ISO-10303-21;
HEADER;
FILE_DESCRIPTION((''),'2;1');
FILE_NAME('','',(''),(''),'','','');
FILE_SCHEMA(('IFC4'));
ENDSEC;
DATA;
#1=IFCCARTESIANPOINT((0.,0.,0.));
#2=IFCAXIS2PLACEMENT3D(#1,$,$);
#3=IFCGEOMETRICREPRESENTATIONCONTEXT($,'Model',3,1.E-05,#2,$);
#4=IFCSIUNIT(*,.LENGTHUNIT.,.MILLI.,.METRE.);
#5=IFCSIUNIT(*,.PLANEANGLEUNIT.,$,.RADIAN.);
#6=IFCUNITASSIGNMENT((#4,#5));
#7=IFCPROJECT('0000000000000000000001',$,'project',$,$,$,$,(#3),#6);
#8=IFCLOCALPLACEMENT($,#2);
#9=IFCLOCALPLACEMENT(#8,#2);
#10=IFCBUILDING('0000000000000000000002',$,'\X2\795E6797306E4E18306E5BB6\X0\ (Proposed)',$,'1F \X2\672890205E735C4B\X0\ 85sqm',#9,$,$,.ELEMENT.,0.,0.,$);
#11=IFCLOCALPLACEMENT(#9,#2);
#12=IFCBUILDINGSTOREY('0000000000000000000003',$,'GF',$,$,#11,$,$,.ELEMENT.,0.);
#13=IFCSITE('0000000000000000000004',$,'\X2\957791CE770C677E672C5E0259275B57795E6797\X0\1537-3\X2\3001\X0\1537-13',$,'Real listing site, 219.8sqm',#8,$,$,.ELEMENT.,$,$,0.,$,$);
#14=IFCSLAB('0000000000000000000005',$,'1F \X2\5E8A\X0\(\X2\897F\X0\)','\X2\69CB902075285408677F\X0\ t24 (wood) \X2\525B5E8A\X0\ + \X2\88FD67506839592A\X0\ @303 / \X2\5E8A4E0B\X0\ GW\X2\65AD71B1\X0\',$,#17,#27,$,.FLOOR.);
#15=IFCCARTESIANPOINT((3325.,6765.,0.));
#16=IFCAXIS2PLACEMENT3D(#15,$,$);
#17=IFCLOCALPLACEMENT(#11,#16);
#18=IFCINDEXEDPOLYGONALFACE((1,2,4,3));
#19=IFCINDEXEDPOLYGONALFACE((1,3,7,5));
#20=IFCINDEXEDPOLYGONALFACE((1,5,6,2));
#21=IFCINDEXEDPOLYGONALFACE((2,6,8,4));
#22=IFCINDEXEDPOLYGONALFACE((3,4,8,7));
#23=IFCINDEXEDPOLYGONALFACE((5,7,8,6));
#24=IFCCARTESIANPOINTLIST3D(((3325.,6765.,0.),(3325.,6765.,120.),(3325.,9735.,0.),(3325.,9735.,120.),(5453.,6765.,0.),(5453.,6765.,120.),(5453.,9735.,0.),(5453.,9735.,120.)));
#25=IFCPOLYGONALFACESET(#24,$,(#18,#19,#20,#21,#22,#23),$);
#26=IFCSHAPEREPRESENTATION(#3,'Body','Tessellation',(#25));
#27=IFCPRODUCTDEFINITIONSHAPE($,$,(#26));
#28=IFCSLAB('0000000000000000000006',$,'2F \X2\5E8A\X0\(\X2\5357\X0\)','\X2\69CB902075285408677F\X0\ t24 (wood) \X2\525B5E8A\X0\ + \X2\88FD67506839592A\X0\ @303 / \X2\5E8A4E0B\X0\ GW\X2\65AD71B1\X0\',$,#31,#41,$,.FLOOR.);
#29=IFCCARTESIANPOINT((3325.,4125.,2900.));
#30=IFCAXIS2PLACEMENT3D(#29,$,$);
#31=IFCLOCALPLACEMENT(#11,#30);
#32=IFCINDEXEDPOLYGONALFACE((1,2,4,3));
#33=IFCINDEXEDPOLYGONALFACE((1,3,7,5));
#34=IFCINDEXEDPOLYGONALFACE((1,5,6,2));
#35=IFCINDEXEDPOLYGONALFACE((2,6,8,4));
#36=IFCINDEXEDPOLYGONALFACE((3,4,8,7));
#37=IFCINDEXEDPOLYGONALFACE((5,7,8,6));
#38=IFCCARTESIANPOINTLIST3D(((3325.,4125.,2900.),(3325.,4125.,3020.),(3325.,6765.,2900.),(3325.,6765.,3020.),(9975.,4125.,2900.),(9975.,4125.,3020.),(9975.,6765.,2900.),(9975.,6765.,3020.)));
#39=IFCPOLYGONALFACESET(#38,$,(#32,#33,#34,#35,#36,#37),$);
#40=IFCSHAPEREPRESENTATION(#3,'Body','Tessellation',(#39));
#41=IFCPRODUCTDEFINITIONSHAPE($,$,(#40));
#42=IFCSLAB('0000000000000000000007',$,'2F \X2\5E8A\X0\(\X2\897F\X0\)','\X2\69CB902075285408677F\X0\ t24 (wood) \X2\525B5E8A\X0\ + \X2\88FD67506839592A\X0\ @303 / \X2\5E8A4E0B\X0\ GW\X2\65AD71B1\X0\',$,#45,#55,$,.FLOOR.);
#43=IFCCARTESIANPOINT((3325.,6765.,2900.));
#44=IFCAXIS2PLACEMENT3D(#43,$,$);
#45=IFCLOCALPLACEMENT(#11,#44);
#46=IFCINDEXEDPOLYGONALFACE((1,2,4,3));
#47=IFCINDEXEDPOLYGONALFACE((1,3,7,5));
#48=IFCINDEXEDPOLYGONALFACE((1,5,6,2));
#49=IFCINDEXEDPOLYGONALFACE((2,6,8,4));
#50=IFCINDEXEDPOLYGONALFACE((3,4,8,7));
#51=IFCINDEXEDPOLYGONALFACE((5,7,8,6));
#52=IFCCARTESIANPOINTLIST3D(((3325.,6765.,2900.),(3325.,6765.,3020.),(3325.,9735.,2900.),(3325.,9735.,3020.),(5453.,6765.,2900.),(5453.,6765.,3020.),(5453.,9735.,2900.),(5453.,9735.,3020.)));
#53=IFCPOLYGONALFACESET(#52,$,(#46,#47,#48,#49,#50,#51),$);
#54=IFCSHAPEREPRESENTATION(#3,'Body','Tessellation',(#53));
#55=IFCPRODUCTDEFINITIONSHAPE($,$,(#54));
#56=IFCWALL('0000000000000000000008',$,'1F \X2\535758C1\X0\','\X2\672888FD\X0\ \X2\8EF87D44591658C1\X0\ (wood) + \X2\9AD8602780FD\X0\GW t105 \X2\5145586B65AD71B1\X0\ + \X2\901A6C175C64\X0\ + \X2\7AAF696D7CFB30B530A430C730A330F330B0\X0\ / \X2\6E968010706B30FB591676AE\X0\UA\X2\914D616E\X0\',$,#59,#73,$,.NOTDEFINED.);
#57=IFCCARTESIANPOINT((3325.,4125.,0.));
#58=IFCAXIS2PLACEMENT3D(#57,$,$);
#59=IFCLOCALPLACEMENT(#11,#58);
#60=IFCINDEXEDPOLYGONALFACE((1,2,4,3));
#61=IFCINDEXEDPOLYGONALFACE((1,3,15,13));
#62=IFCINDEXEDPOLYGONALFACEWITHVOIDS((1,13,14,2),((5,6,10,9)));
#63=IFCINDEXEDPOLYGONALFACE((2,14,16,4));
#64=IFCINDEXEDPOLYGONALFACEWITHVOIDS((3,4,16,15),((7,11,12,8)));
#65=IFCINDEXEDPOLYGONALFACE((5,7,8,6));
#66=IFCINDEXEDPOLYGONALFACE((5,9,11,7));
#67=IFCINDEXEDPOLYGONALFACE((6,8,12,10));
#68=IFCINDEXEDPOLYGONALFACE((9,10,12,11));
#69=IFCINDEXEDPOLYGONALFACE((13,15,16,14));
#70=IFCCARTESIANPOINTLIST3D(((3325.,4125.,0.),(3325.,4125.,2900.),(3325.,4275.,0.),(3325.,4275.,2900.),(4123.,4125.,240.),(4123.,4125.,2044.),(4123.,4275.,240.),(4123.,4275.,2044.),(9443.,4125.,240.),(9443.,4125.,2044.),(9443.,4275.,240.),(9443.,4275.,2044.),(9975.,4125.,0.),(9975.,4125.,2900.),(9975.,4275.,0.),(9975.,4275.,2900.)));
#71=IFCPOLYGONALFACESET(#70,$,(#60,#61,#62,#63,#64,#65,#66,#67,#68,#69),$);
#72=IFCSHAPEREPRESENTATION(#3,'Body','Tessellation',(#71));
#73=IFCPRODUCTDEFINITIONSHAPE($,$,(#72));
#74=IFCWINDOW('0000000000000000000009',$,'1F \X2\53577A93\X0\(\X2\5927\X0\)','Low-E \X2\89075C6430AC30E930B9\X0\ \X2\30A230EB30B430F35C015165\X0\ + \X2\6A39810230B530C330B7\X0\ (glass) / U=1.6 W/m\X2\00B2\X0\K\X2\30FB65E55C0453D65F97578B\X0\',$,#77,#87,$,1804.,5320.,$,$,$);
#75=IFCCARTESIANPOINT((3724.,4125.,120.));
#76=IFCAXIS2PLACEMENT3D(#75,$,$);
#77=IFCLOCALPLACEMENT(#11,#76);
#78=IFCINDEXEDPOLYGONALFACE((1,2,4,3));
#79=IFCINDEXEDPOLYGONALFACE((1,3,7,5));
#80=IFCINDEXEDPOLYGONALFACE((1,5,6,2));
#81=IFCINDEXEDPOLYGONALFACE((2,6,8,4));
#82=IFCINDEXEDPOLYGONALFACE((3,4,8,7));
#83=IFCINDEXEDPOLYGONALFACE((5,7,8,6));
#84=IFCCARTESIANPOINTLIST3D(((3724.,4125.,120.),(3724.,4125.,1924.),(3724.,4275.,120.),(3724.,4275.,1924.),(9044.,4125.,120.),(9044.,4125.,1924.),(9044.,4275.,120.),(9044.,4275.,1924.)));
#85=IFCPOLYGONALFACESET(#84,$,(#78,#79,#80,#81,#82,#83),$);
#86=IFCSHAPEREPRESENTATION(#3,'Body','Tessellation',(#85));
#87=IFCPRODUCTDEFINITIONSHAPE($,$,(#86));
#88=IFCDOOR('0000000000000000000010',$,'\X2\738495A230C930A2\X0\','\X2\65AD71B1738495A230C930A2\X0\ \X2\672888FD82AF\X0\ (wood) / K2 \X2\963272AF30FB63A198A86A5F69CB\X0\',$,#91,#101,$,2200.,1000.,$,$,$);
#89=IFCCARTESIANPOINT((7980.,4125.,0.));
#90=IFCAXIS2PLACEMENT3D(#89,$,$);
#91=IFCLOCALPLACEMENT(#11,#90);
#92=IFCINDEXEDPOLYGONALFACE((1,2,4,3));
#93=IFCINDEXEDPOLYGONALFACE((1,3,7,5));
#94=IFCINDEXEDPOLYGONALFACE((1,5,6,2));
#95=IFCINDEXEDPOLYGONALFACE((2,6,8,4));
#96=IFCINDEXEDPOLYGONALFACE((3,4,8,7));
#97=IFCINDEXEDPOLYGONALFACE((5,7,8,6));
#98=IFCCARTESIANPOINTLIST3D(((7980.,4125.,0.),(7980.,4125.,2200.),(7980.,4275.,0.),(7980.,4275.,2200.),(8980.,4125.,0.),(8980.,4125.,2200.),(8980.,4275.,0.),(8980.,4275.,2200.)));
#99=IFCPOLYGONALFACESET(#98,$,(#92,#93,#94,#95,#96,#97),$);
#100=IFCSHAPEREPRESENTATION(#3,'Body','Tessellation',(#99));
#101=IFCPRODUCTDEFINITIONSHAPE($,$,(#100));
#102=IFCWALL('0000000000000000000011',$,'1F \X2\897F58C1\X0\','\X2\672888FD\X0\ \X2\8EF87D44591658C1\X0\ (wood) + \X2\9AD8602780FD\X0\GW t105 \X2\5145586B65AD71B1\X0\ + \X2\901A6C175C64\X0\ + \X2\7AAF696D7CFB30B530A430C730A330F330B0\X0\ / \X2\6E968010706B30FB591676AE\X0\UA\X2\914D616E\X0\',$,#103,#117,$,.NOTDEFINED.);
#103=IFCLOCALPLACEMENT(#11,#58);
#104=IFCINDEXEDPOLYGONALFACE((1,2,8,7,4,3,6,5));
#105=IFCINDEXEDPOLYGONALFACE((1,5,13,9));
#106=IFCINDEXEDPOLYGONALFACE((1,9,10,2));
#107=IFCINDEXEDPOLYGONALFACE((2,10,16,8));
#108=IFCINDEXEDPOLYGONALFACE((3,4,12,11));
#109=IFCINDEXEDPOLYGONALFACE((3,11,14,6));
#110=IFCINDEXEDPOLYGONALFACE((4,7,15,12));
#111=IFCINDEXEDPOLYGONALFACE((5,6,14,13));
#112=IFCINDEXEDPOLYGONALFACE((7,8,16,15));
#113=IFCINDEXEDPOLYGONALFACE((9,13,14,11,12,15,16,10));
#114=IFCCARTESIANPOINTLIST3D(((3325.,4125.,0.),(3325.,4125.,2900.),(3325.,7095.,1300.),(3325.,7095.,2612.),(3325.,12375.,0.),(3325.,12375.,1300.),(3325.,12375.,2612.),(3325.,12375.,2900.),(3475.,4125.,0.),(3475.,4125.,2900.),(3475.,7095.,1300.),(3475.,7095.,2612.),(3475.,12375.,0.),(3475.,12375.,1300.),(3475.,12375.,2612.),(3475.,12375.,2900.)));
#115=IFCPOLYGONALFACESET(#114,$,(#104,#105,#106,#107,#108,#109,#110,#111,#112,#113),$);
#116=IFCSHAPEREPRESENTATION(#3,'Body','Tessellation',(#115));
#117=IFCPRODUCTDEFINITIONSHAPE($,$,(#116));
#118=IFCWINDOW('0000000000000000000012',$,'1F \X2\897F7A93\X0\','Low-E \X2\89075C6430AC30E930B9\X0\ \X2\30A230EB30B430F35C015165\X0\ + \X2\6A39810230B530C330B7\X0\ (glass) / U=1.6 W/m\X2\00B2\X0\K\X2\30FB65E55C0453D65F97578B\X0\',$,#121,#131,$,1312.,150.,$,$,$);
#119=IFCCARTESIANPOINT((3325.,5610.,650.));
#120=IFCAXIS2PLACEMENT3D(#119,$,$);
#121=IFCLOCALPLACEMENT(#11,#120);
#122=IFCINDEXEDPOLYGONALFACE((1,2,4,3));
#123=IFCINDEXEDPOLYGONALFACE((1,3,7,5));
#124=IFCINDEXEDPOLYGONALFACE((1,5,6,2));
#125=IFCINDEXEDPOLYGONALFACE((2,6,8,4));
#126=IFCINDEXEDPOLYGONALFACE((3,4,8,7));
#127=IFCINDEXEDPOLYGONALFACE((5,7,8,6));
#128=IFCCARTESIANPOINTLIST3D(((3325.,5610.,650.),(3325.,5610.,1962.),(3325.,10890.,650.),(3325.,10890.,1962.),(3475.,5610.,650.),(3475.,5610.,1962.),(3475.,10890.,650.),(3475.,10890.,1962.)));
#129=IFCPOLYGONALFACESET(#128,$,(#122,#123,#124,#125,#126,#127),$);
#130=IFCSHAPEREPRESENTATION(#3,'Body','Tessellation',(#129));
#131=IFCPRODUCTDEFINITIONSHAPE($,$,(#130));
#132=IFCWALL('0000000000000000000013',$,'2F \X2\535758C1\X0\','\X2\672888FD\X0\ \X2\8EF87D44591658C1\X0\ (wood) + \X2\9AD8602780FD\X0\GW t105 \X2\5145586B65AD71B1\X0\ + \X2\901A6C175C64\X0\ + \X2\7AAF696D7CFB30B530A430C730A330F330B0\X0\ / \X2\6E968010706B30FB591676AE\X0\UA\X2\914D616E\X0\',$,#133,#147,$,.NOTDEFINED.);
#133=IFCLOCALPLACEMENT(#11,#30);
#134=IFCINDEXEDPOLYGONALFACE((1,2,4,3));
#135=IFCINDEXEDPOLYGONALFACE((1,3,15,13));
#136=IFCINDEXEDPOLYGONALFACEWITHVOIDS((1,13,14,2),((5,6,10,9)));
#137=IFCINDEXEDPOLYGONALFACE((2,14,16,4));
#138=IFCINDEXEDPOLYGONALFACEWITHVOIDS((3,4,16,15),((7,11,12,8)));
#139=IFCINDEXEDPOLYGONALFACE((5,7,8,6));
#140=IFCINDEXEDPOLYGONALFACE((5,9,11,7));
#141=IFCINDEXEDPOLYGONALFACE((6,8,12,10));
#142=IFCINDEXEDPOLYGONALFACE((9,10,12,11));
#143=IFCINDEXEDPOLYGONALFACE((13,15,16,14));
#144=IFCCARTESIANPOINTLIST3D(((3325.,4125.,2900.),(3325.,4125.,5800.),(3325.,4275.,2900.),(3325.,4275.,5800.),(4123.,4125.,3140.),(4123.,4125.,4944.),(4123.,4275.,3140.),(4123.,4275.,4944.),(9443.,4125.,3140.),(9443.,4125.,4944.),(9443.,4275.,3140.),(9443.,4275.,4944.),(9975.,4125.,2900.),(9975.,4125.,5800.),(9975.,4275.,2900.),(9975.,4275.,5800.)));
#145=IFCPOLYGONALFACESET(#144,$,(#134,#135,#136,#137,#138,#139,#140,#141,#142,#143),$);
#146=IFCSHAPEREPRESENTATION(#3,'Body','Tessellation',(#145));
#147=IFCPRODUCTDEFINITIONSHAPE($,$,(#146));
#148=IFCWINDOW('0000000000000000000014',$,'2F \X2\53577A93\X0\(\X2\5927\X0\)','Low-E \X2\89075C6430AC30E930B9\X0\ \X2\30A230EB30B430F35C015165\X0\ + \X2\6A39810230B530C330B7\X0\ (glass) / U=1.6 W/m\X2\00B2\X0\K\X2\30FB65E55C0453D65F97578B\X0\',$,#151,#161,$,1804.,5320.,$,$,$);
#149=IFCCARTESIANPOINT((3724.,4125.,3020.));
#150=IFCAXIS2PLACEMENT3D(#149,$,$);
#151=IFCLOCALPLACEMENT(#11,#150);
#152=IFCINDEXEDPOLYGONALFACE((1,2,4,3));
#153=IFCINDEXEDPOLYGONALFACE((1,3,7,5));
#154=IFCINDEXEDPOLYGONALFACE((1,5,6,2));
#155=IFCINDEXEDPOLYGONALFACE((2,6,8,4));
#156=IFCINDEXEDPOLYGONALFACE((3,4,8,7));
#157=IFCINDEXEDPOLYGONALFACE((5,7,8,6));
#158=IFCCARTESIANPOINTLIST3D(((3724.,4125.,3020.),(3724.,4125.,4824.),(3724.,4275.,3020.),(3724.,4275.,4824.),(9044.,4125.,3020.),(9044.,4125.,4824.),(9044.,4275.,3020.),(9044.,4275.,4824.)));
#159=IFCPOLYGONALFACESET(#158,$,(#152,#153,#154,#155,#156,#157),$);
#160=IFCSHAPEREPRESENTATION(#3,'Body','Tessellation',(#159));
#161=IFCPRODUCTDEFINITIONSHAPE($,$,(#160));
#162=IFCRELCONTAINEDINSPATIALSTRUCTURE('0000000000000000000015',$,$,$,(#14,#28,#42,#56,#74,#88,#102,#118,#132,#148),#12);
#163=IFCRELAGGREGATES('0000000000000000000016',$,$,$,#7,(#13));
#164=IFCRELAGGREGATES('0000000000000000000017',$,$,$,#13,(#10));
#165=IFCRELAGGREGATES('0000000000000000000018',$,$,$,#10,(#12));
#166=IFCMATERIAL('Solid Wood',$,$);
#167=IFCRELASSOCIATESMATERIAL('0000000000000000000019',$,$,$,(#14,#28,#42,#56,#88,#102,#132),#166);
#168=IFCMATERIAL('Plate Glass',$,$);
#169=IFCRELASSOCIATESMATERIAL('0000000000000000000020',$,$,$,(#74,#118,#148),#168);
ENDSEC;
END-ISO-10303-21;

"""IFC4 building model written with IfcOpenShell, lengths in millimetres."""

from ifc_helpers import new_model, si_unit, frame, frame_2d, origin, place, context, project, spatial, rectangle, extrude, material, element, fill, save


model = new_model("IFC4")

# Units and contexts
model_context = context("Model", 3, precision=1e-05, world=origin())
ifc_project = project(units=[si_unit("LENGTHUNIT", "METRE", prefix="MILLI"), si_unit("PLANEANGLEUNIT", "RADIAN")], contexts=[model_context])

# Site, building, storey
site_placement = place(None, origin())
site = spatial("IfcSite", under=ifc_project, at=site_placement, Name="長野県松本市大字神林1537-3、1537-13", ObjectType="Real listing site, 219.8sqm", CompositionType="ELEMENT", RefElevation=0.0)
building_placement = place(site_placement, origin())
building = spatial("IfcBuilding", under=site, at=building_placement, Name="神林の丘の家 (Proposed)", ObjectType="1F 木造平屋 85sqm", CompositionType="ELEMENT", ElevationOfRefHeight=0.0, ElevationOfTerrain=0.0)
storey_placement = place(building_placement, origin())
storey = spatial("IfcBuildingStorey", under=building, at=storey_placement, Name="GF", CompositionType="ELEMENT", Elevation=0.0)

# Slabs
ifc_material_1 = material(Name="Solid Wood")
slab_1_placement = place(storey_placement, frame((3325.0, 6765.0, 0.0)))
element("IfcSlab", 1, at=slab_1_placement, inside=storey, material=ifc_material_1, Name="1F 床(西)", Description="構造用合板 t24 (wood) 剛床 + 製材根太 @303 / 床下 GW断熱", PredefinedType="FLOOR", context=model_context, shape_type="SweptSolid", body=[
    extrude(rectangle(XDim=2128.0, YDim=2970.0, at=frame_2d((1064.0, 1485.0))), frame((3325.0, 6765.0, 0.0)), (0.0, 0.0, 1.0), 120.0),
])
slab_2_placement = place(storey_placement, frame((3325.0, 4125.0, 2900.0)))
element("IfcSlab", 2, at=slab_2_placement, inside=storey, material=ifc_material_1, Name="2F 床(南)", Description="構造用合板 t24 (wood) 剛床 + 製材根太 @303 / 床下 GW断熱", PredefinedType="FLOOR", context=model_context, shape_type="SweptSolid", body=[
    extrude(rectangle(XDim=6650.0, YDim=2640.0, at=frame_2d((3325.0, 1320.0))), frame((3325.0, 4125.0, 2900.0)), (0.0, 0.0, 1.0), 120.0),
])
slab_3_placement = place(storey_placement, frame((3325.0, 6765.0, 2900.0)))
element("IfcSlab", 3, at=slab_3_placement, inside=storey, material=ifc_material_1, Name="2F 床(西)", Description="構造用合板 t24 (wood) 剛床 + 製材根太 @303 / 床下 GW断熱", PredefinedType="FLOOR", context=model_context, shape_type="SweptSolid", body=[
    extrude(rectangle(XDim=2128.0, YDim=2970.0, at=frame_2d((1064.0, 1485.0))), frame((3325.0, 6765.0, 2900.0)), (0.0, 0.0, 1.0), 120.0),
])

# Wall, openings, window, door
wall_1_placement = place(storey_placement, frame((3325.0, 4125.0, 0.0)))
wall_1 = element("IfcWall", 4, at=wall_1_placement, inside=storey, material=ifc_material_1, Name="1F 南壁", Description="木製 軸組外壁 (wood) + 高性能GW t105 充填断熱 + 通気層 + 窯業系サイディング / 準耐火・外皮UA配慮", PredefinedType="NOTDEFINED", context=model_context, shape_type="SweptSolid", body=[
    extrude(rectangle(XDim=6650.0, YDim=150.0, at=frame_2d((3325.0, 75.0))), frame((3325.0, 4125.0, 0.0)), (0.0, 0.0, 1.0), 2900.0),
])
opening_1_placement = place(storey_placement, frame((3724.0, 4125.0, 120.0)))
opening_1 = element("IfcOpeningElement", 5, at=opening_1_placement, cuts=wall_1, PredefinedType="NOTDEFINED", context=model_context, shape_type="SweptSolid", body=[
    extrude(rectangle(XDim=5320.0, YDim=150.0, at=frame_2d((2660.0, 75.0))), frame((3724.0, 4125.0, 120.0)), (0.0, 0.0, 1.0), 1804.0),
])
opening_2_placement = place(storey_placement, frame((7980.0, 4125.0, 0.0)))
opening_2 = element("IfcOpeningElement", 6, at=opening_2_placement, cuts=wall_1, PredefinedType="NOTDEFINED", context=model_context, shape_type="SweptSolid", body=[
    extrude(rectangle(XDim=1000.0, YDim=150.0, at=frame_2d((500.0, 75.0))), frame((7980.0, 4125.0, 0.0)), (0.0, 0.0, 1.0), 2200.0),
])
ifc_material_2 = material(Name="Plate Glass")
window_1_placement = place(storey_placement, frame((3724.0, 4125.0, 120.0)))
window_1 = element("IfcWindow", 7, at=window_1_placement, inside=storey, material=ifc_material_2, Name="1F 南窓(大)", Description="Low-E 複層ガラス アルゴン封入 + 樹脂サッシ (glass) / U=1.6 W/m²K・日射取得型", OverallHeight=1804.0, OverallWidth=5320.0, context=model_context, shape_type="SweptSolid", body=[
    extrude(rectangle(XDim=5320.0, YDim=150.0, at=frame_2d((2660.0, 75.0))), frame((3724.0, 4125.0, 120.0)), (0.0, 0.0, 1.0), 1804.0),
])
fill(opening_1, window_1)
door_placement = place(storey_placement, frame((7980.0, 4125.0, 0.0)))
door = element("IfcDoor", 8, at=door_placement, inside=storey, material=ifc_material_1, Name="玄関ドア", Description="断熱玄関ドア 木製芯 (wood) / K2 防犯・採風機構", OverallHeight=2200.0, OverallWidth=1000.0, context=model_context, shape_type="SweptSolid", body=[
    extrude(rectangle(XDim=1000.0, YDim=150.0, at=frame_2d((500.0, 75.0))), frame((7980.0, 4125.0, 0.0)), (0.0, 0.0, 1.0), 2200.0),
])
fill(opening_2, door)

# Walls, openings, windows
wall_2_placement = place(storey_placement, frame((3325.0, 4125.0, 0.0)))
wall_2 = element("IfcWall", 9, at=wall_2_placement, inside=storey, material=ifc_material_1, Name="1F 西壁", Description="木製 軸組外壁 (wood) + 高性能GW t105 充填断熱 + 通気層 + 窯業系サイディング / 準耐火・外皮UA配慮", PredefinedType="NOTDEFINED", context=model_context, shape_type="SweptSolid", body=[
    extrude(rectangle(XDim=150.0, YDim=8250.0, at=frame_2d((75.0, 4125.0))), frame((3325.0, 4125.0, 0.0)), (0.0, 0.0, 1.0), 2900.0),
])
opening_3_placement = place(storey_placement, frame((3325.0, 5610.0, 650.0)))
opening_3 = element("IfcOpeningElement", 10, at=opening_3_placement, cuts=wall_2, PredefinedType="NOTDEFINED", context=model_context, shape_type="SweptSolid", body=[
    extrude(rectangle(XDim=150.0, YDim=5280.0, at=frame_2d((75.0, 2640.0))), frame((3325.0, 5610.0, 650.0)), (0.0, 0.0, 1.0), 1312.0),
])
window_2_placement = place(storey_placement, frame((3325.0, 5610.0, 650.0)))
window_2 = element("IfcWindow", 11, at=window_2_placement, inside=storey, material=ifc_material_2, Name="1F 西窓", Description="Low-E 複層ガラス アルゴン封入 + 樹脂サッシ (glass) / U=1.6 W/m²K・日射取得型", OverallHeight=1312.0, OverallWidth=150.0, context=model_context, shape_type="SweptSolid", body=[
    extrude(rectangle(XDim=150.0, YDim=5280.0, at=frame_2d((75.0, 2640.0))), frame((3325.0, 5610.0, 650.0)), (0.0, 0.0, 1.0), 1312.0),
])
fill(opening_3, window_2)
wall_3_placement = place(storey_placement, frame((3325.0, 4125.0, 2900.0)))
wall_3 = element("IfcWall", 12, at=wall_3_placement, inside=storey, material=ifc_material_1, Name="2F 南壁", Description="木製 軸組外壁 (wood) + 高性能GW t105 充填断熱 + 通気層 + 窯業系サイディング / 準耐火・外皮UA配慮", PredefinedType="NOTDEFINED", context=model_context, shape_type="SweptSolid", body=[
    extrude(rectangle(XDim=6650.0, YDim=150.0, at=frame_2d((3325.0, 75.0))), frame((3325.0, 4125.0, 2900.0)), (0.0, 0.0, 1.0), 2900.0),
])
opening_4_placement = place(storey_placement, frame((3724.0, 4125.0, 3020.0)))
opening_4 = element("IfcOpeningElement", 13, at=opening_4_placement, cuts=wall_3, PredefinedType="NOTDEFINED", context=model_context, shape_type="SweptSolid", body=[
    extrude(rectangle(XDim=5320.0, YDim=150.0, at=frame_2d((2660.0, 75.0))), frame((3724.0, 4125.0, 3020.0)), (0.0, 0.0, 1.0), 1804.0),
])
window_3_placement = place(storey_placement, frame((3724.0, 4125.0, 3020.0)))
window_3 = element("IfcWindow", 14, at=window_3_placement, inside=storey, material=ifc_material_2, Name="2F 南窓(大)", Description="Low-E 複層ガラス アルゴン封入 + 樹脂サッシ (glass) / U=1.6 W/m²K・日射取得型", OverallHeight=1804.0, OverallWidth=5320.0, context=model_context, shape_type="SweptSolid", body=[
    extrude(rectangle(XDim=5320.0, YDim=150.0, at=frame_2d((2660.0, 75.0))), frame((3724.0, 4125.0, 3020.0)), (0.0, 0.0, 1.0), 1804.0),
])
fill(opening_4, window_3)

save(model, "model.ifc")
